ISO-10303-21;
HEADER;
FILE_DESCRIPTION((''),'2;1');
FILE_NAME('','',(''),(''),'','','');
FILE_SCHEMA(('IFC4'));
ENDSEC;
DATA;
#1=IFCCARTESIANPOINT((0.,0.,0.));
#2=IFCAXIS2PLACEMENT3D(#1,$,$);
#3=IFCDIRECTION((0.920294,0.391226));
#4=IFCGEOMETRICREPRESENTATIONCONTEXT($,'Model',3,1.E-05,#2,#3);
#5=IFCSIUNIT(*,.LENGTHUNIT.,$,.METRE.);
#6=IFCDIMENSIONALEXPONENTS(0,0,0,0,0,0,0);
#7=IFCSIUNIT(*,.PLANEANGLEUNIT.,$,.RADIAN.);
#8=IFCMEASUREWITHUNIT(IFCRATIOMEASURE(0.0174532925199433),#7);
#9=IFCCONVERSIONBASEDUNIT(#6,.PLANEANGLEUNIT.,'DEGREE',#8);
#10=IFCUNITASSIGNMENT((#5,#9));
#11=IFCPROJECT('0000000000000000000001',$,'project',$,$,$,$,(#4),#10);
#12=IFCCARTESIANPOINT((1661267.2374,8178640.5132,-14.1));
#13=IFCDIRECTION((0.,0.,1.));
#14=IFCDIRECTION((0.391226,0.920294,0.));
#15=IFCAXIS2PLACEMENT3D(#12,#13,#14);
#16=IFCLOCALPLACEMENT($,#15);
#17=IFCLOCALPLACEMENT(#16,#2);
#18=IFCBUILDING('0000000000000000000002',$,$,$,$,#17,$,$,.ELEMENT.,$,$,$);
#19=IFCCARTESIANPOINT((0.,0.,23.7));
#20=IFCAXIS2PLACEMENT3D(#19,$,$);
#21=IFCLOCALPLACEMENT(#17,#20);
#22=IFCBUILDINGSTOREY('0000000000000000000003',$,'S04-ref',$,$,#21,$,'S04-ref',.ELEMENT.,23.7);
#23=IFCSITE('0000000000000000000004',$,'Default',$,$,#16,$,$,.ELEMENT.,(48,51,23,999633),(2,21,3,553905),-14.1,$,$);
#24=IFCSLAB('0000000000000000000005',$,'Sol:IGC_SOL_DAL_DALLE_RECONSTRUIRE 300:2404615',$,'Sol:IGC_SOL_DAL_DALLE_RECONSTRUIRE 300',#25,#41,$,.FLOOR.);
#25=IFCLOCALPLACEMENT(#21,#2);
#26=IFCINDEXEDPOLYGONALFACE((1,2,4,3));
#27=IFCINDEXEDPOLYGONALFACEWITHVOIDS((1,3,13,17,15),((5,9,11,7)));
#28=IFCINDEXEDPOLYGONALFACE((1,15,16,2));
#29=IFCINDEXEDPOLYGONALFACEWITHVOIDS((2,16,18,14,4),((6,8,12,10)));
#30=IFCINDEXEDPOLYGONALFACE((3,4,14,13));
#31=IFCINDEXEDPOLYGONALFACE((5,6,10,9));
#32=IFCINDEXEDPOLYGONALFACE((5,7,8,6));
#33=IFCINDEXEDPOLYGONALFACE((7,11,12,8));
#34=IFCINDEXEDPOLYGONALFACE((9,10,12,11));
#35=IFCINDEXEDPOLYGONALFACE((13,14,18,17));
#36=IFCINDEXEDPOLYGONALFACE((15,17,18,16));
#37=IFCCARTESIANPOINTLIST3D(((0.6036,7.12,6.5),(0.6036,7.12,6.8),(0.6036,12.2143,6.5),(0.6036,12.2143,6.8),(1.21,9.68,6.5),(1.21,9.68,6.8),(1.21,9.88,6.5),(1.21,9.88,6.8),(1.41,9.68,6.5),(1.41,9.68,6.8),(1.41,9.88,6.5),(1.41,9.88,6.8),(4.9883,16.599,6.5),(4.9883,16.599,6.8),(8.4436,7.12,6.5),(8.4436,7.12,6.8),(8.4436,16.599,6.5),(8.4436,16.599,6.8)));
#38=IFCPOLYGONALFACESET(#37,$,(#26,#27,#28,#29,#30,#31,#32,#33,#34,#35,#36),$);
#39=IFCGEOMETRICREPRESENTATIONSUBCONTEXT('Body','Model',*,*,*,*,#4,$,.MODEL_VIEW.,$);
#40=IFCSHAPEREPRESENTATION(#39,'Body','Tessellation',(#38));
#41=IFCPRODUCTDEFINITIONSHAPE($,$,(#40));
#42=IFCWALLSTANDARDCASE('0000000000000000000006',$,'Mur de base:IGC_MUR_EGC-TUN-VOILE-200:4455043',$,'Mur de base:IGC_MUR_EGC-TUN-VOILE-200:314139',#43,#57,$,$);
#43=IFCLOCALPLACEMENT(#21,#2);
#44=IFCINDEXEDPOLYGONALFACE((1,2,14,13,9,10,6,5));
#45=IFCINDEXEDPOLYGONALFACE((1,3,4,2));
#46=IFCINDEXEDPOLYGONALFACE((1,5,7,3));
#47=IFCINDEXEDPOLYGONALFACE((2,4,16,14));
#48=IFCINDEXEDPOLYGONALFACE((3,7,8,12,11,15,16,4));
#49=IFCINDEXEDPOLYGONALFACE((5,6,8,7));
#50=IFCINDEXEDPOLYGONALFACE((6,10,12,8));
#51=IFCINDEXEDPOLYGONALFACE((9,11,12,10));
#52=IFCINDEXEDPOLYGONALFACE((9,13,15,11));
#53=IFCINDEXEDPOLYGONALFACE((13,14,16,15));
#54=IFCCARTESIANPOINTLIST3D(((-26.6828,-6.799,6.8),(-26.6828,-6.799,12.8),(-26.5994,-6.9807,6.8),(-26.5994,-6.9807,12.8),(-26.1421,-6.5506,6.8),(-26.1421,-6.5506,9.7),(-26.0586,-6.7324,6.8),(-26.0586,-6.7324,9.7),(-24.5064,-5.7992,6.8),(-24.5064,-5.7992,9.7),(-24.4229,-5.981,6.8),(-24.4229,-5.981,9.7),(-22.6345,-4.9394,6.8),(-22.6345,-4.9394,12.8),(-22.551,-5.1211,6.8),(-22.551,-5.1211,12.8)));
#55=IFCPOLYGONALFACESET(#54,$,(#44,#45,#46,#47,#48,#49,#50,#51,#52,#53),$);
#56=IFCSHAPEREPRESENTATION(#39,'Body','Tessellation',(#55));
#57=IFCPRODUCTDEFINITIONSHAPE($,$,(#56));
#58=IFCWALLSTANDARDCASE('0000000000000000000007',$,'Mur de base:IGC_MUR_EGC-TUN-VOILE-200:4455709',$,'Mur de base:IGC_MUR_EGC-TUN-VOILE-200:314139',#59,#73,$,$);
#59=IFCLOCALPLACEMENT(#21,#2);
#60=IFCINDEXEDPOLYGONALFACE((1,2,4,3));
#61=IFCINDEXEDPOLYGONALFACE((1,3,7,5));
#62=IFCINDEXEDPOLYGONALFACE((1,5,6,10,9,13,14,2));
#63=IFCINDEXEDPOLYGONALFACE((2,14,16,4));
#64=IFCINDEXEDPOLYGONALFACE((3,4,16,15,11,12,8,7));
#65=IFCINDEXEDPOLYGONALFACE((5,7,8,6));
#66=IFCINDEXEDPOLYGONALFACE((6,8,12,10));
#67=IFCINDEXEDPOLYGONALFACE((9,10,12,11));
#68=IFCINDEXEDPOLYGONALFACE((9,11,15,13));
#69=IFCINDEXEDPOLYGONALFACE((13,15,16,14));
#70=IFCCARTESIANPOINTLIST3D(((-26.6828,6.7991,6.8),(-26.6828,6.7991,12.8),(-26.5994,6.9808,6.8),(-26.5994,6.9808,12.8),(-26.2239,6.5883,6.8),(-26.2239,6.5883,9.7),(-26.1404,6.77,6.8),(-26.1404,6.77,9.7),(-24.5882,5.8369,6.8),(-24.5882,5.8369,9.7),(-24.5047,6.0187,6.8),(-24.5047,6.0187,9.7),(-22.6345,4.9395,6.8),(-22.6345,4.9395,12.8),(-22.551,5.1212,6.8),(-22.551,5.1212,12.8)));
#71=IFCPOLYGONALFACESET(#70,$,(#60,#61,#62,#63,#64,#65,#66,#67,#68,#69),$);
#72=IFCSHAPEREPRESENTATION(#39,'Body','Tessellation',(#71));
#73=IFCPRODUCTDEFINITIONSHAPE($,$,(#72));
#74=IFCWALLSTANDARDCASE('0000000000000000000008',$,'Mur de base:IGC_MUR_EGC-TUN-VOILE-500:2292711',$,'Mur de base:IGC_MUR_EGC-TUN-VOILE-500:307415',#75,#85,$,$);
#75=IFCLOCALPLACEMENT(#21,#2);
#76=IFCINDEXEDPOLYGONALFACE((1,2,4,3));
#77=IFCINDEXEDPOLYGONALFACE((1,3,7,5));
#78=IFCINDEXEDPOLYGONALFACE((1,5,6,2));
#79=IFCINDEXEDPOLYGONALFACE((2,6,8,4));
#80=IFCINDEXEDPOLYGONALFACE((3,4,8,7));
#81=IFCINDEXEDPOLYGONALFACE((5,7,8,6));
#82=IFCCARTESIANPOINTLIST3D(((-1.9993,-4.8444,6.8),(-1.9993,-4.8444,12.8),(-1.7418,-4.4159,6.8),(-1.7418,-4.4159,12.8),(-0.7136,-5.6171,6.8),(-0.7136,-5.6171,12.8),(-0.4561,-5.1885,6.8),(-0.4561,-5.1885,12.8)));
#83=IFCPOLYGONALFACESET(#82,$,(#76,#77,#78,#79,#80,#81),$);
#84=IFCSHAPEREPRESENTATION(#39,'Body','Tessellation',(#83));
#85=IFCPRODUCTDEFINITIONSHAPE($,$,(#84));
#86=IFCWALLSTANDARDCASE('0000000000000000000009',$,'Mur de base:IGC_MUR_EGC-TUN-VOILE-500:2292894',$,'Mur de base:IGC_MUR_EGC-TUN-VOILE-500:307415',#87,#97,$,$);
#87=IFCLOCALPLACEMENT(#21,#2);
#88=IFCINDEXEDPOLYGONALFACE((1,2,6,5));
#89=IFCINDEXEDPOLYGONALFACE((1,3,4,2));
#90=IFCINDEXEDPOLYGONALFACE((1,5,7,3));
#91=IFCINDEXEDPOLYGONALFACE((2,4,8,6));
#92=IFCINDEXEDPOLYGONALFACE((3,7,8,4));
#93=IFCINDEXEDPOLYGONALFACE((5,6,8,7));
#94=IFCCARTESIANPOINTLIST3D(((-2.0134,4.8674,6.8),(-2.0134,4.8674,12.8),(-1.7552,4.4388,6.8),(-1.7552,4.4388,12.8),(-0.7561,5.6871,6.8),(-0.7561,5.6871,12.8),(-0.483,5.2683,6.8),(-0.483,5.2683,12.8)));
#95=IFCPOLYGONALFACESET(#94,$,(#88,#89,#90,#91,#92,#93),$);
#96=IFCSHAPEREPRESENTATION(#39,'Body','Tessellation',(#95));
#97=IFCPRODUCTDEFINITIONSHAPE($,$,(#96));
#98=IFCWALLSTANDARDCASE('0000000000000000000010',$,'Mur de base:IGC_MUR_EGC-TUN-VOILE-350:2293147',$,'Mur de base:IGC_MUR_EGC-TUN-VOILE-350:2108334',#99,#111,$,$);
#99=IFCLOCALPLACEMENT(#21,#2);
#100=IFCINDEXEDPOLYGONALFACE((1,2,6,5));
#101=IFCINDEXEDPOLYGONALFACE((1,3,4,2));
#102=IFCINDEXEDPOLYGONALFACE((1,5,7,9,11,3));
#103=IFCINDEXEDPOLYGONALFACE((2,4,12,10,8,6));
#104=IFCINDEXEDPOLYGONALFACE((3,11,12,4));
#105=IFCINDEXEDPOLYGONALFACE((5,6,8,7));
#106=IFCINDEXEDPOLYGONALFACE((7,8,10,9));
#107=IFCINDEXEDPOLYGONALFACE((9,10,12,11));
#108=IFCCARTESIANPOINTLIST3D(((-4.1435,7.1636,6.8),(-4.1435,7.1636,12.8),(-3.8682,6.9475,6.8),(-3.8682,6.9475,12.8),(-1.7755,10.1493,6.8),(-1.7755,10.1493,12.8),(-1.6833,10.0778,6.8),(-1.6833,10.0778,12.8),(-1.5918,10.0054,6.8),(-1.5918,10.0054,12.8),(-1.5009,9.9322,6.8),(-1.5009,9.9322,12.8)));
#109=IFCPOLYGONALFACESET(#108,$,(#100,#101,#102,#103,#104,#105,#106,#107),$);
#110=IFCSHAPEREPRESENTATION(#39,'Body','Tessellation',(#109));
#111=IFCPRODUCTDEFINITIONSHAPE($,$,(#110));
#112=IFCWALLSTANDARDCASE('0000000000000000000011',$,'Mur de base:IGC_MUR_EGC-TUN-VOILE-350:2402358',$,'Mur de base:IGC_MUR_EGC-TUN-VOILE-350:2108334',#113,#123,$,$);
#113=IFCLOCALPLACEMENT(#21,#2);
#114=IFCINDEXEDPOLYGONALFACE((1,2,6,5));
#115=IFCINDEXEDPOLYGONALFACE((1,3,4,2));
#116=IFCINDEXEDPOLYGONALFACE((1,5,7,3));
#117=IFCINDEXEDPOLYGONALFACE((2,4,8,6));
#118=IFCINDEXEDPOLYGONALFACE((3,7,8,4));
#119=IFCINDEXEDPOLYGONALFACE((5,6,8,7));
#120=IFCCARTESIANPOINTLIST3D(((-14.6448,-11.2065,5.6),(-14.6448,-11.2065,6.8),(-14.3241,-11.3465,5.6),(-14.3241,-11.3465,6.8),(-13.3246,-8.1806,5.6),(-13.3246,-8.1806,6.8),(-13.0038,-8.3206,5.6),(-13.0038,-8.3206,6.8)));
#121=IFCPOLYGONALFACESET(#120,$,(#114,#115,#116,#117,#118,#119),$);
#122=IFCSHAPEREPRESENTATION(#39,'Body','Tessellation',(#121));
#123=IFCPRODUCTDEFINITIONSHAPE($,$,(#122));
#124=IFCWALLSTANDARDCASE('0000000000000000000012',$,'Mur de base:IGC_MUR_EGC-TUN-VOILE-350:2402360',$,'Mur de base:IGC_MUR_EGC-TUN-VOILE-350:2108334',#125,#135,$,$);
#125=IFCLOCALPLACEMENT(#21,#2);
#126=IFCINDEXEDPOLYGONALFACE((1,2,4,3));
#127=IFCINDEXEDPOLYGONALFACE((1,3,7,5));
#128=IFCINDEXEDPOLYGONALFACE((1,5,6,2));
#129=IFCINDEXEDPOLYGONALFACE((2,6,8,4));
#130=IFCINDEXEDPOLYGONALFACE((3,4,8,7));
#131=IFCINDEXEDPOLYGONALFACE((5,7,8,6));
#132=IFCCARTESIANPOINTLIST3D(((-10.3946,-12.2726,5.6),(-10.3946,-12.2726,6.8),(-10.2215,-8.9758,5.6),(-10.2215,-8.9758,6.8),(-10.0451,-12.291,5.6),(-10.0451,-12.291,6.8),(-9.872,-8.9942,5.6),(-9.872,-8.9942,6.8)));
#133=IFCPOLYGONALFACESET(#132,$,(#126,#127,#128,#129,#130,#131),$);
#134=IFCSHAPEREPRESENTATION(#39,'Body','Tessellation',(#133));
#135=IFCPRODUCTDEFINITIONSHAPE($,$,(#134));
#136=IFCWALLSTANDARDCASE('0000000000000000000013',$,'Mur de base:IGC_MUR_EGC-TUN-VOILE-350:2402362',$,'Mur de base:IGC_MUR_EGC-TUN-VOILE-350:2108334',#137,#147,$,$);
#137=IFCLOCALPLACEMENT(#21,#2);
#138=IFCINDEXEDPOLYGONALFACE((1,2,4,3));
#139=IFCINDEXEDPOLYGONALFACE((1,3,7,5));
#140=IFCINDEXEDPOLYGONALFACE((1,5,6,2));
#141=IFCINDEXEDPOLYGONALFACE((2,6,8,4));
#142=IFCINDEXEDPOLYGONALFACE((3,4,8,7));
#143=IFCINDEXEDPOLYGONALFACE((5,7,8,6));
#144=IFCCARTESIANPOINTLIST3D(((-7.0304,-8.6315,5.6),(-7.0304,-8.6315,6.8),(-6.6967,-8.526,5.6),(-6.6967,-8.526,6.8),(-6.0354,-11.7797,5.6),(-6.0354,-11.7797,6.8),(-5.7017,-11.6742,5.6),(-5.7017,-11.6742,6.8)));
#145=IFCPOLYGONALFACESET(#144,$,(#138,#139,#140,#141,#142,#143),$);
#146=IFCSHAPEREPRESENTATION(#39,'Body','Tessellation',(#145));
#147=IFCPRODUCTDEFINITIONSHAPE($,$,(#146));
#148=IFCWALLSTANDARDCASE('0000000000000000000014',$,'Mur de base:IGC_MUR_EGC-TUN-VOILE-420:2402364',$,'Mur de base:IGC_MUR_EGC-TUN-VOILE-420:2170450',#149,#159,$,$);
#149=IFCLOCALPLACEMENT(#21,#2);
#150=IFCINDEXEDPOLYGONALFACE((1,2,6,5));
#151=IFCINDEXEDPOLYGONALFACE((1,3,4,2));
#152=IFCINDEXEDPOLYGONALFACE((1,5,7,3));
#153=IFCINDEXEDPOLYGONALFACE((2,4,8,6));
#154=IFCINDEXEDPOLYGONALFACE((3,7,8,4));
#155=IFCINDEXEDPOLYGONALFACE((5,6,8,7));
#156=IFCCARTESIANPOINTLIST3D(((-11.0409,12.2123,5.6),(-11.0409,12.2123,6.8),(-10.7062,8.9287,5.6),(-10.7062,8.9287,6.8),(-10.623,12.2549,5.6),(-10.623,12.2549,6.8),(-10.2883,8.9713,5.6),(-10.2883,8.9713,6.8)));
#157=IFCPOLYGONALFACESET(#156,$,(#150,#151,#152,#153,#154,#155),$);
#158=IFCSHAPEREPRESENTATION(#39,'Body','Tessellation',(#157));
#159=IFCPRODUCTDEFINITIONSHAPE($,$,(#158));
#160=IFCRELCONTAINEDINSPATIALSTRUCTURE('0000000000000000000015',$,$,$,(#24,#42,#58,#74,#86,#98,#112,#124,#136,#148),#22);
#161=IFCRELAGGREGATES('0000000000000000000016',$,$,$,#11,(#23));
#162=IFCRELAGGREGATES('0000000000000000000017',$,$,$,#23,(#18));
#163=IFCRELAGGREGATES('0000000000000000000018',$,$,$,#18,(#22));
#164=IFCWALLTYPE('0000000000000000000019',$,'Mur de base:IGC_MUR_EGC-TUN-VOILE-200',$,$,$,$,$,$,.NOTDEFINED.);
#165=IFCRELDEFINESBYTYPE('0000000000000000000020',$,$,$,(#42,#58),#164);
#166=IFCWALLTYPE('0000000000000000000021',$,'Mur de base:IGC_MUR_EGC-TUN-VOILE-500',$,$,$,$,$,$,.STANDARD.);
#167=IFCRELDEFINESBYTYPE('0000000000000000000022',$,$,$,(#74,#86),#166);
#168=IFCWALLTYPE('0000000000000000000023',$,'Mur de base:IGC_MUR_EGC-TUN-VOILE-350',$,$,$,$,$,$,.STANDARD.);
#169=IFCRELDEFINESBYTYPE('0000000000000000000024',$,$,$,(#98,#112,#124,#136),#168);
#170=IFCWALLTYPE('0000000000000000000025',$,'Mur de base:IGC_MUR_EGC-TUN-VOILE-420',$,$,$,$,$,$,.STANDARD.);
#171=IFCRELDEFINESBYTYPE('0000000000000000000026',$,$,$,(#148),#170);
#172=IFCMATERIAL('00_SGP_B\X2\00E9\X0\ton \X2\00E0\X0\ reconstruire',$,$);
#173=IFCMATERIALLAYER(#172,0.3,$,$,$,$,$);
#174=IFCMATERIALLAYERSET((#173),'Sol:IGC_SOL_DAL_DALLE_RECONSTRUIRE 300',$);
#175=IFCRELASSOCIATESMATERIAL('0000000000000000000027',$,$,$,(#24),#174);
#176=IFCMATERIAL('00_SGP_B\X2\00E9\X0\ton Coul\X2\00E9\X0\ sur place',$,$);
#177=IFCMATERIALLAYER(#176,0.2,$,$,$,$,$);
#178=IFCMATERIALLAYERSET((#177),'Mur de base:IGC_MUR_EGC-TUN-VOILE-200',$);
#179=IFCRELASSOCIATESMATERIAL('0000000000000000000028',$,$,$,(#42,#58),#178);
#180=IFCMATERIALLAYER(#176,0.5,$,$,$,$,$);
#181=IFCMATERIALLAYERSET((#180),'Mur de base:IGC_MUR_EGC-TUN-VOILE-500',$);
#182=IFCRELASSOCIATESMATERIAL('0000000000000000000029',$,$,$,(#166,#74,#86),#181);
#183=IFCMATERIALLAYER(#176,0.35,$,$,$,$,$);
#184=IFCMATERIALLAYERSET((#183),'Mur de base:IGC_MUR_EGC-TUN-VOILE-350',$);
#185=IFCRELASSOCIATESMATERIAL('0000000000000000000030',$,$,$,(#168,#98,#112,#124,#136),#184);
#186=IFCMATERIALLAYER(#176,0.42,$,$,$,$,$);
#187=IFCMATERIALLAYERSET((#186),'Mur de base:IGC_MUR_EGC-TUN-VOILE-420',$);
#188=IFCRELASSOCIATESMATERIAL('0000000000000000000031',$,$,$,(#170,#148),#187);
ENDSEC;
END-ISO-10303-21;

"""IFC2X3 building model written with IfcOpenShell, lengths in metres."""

from ifc_helpers import new_model, entity, si_unit, converted_unit, direction, frame, frame_2d, origin, origin_2d_with_axis, place, context, subcontext, project, spatial, polyline, circle_curve, parameter, trimmed, segment, composite_curve, rectangle, outline, extrude, clip, bounded_halfspace, material, layer, layer_set, layer_usage, type_object, element, save


model = new_model("IFC2X3")

# Units and contexts
model_context = context("Model", 3, precision=1e-05, world=origin(), true_north=direction((0.920294, 0.391226)))
body_context = subcontext(model_context, "Body", "Model", "MODEL_VIEW")
ifc_project = project(units=[si_unit("LENGTHUNIT", "METRE"), converted_unit("PLANEANGLEUNIT", "DEGREE", entity("IfcRatioMeasure", 0.0174532925199433), si_unit("PLANEANGLEUNIT", "RADIAN"), dimensions=[0, 0, 0, 0, 0, 0, 0])], contexts=[model_context])

# Site, building, storey
site_placement = place(None, frame((1661267.2374, 8178640.5132, -14.1), z_axis=(0.0, 0.0, 1.0), x_axis=(0.391226, 0.920294, 0.0)))
site = spatial("IfcSite", under=ifc_project, at=site_placement, Name="Default", CompositionType="ELEMENT", RefLatitude=(48, 51, 23, 999633), RefLongitude=(2, 21, 3, 553905), RefElevation=-14.1)
building_placement = place(site_placement, origin())
building = spatial("IfcBuilding", under=site, at=building_placement, CompositionType="ELEMENT")
storey_placement = place(building_placement, frame((0.0, 0.0, 23.7)))
storey = spatial("IfcBuildingStorey", under=building, at=storey_placement, Name="S04-ref", LongName="S04-ref", CompositionType="ELEMENT", Elevation=23.7)

# Slab, opening
ifc_material_1 = material(Name="00_SGP_Béton à reconstruire")
ifc_layer_1 = layer(ifc_material_1, 0.3)
ifc_layer_set_1 = layer_set([ifc_layer_1], Name="Sol:IGC_SOL_DAL_DALLE_RECONSTRUIRE 300")
ifc_layer_usage_1 = layer_usage(ifc_layer_set_1, "AXIS3", "POSITIVE", 0.0)
slab_placement = place(storey_placement, frame((0.6036, 7.12, 6.5)))
slab = element("IfcSlab", 1, at=slab_placement, inside=storey, material=ifc_layer_usage_1, Name="Sol:IGC_SOL_DAL_DALLE_RECONSTRUIRE 300:2404615", ObjectType="Sol:IGC_SOL_DAL_DALLE_RECONSTRUIRE 300", PredefinedType="FLOOR", context=body_context, shape_type="SweptSolid", body=[
    extrude(outline(polyline([(-0.4647, 4.7395), (-3.92, 4.7395), (-3.92, -4.7395), (3.92, -4.7395), (3.92, 0.3548), (-0.4647, 4.7395)])), frame((3.92, 4.7395, 0.3), z_axis=(0.0, 0.0, -1.0), x_axis=(-1.0, 0.0, 0.0)), (0.0, 0.0, 1.0), 0.3),
])
opening_1_placement = place(slab_placement, origin())
element("IfcOpeningElement", 2, at=opening_1_placement, cuts=slab, ObjectType="Opening", context=body_context, shape_type="SweptSolid", body=[
    extrude(rectangle(XDim=0.2, YDim=0.2, at=origin_2d_with_axis()), frame((0.7064, 2.66, 0.0), z_axis=(0.0, 0.0, 1.0), x_axis=(-1.0, 0.0, 0.0)), (0.0, 0.0, 1.0), 0.3),
])

# Shared definitions
ifc_material_2 = material(Name="00_SGP_Béton Coulé sur place")
ifc_layer_2 = layer(ifc_material_2, 0.2)
ifc_layer_set_2 = layer_set([ifc_layer_2], Name="Mur de base:IGC_MUR_EGC-TUN-VOILE-200")
wall_type_1 = type_object("IfcWallType", Name="Mur de base:IGC_MUR_EGC-TUN-VOILE-200", PredefinedType="NOTDEFINED")

# Walls, openings
ifc_layer_usage_2 = layer_usage(ifc_layer_set_2, "AXIS2", "NEGATIVE", 0.1)
wall_1_placement = place(storey_placement, frame((-22.5927, -5.0302, 6.8), z_axis=(0.0, 0.0, 1.0), x_axis=(-0.908712, -0.417423, 0.0)))
wall_1 = element("IfcWallStandardCase", 3, at=wall_1_placement, inside=storey, type_object=wall_type_1, material=ifc_layer_usage_2, Name="Mur de base:IGC_MUR_EGC-TUN-VOILE-200:4455043", ObjectType="Mur de base:IGC_MUR_EGC-TUN-VOILE-200:314139", context=body_context, shape_type="SweptSolid", body=[
    extrude(rectangle(XDim=4.455, YDim=0.2, at=frame_2d((2.2275, 0.0), x_axis=(-1.0, 0.0))), origin(), (0.0, 0.0, 1.0), 6.0),
])
opening_2_placement = place(wall_1_placement, origin())
element("IfcOpeningElement", 4, at=opening_2_placement, cuts=wall_1, ObjectType="Opening", context=body_context, shape_type="SweptSolid", body=[
    extrude(rectangle(XDim=2.9, YDim=1.8, at=frame_2d((0.0, 0.0), x_axis=(0.0, 1.0))), frame((2.96, -1.624, 1.45), z_axis=(0.0, 1.0, 0.0), x_axis=(1.0, 0.0, 0.0)), (0.0, 0.0, 1.0), 3.048),
])
ifc_layer_usage_3 = layer_usage(ifc_layer_set_2, "AXIS2", "POSITIVE", -0.1)
wall_2_placement = place(storey_placement, frame((-22.5927, 5.0303, 6.8), z_axis=(0.0, 0.0, 1.0), x_axis=(-0.908714, 0.417419, 0.0)))
wall_2 = element("IfcWallStandardCase", 5, at=wall_2_placement, inside=storey, type_object=wall_type_1, material=ifc_layer_usage_3, Name="Mur de base:IGC_MUR_EGC-TUN-VOILE-200:4455709", ObjectType="Mur de base:IGC_MUR_EGC-TUN-VOILE-200:314139", context=body_context, shape_type="SweptSolid", body=[
    extrude(rectangle(XDim=4.455, YDim=0.2, at=frame_2d((2.2275, 0.0), x_axis=(-1.0, 0.0))), origin(), (0.0, 0.0, 1.0), 6.0),
])
opening_3_placement = place(wall_2_placement, origin())
element("IfcOpeningElement", 6, at=opening_3_placement, cuts=wall_2, ObjectType="Opening", context=body_context, shape_type="SweptSolid", body=[
    extrude(rectangle(XDim=2.9, YDim=1.8, at=frame_2d((0.0, 0.0), x_axis=(1.0, 0.0))), frame((3.05, -1.424, 1.45), z_axis=(0.0, 1.0, 0.0), x_axis=(0.0, 0.0, -1.0)), (0.0, 0.0, 1.0), 3.048),
])

# Walls
ifc_layer_3 = layer(ifc_material_2, 0.5)
ifc_layer_set_3 = layer_set([ifc_layer_3], Name="Mur de base:IGC_MUR_EGC-TUN-VOILE-500")
ifc_layer_usage_4 = layer_usage(ifc_layer_set_3, "AXIS2", "NEGATIVE", 0.25)
wall_type_2 = type_object("IfcWallType", Name="Mur de base:IGC_MUR_EGC-TUN-VOILE-500", PredefinedType="STANDARD", material=ifc_layer_set_3)
wall_3_placement = place(storey_placement, frame((-0.5848, -5.4028, 6.8), z_axis=(0.0, 0.0, 1.0), x_axis=(-0.857124, 0.51511, 0.0)))
element("IfcWallStandardCase", 7, at=wall_3_placement, inside=storey, type_object=wall_type_2, material=ifc_layer_usage_4, Name="Mur de base:IGC_MUR_EGC-TUN-VOILE-500:2292711", ObjectType="Mur de base:IGC_MUR_EGC-TUN-VOILE-500:307415", context=body_context, shape_type="Clipping", body=[
    clip(extrude(rectangle(XDim=1.5, YDim=0.5, at=frame_2d((0.75, 0.0), x_axis=(-1.0, 0.0))), origin(), (0.0, 0.0, 1.0), 6.0), bounded_halfspace(frame((1.5, -0.25, 6.0), z_axis=(-1.0, -0.000004, 0.0), x_axis=(0.0, 0.0, -1.0)), True, frame((1.5, -0.25, 6.0), z_axis=(-1.0, -0.000004, 0.0), x_axis=(0.0, 0.0, -1.0)), polyline([(0.0, 0.0), (0.0, -0.5), (6.0, -0.5), (6.0, 0.0), (0.0, 0.0)]))),
])
ifc_layer_usage_5 = layer_usage(ifc_layer_set_3, "AXIS2", "NEGATIVE", 0.25)
wall_4_placement = place(storey_placement, frame((-0.6195, 5.4777, 6.8), z_axis=(0.0, 0.0, 1.0), x_axis=(-0.837669, -0.546179, 0.0)))
element("IfcWallStandardCase", 8, at=wall_4_placement, inside=storey, type_object=wall_type_2, material=ifc_layer_usage_5, Name="Mur de base:IGC_MUR_EGC-TUN-VOILE-500:2292894", ObjectType="Mur de base:IGC_MUR_EGC-TUN-VOILE-500:307415", context=body_context, shape_type="Clipping", body=[
    clip(extrude(rectangle(XDim=1.5187, YDim=0.5, at=frame_2d((0.7594, 0.0), x_axis=(-1.0, 0.0))), origin(), (0.0, 0.0, 1.0), 6.0), bounded_halfspace(frame((1.5009, -0.25, 6.0), z_axis=(-0.999367, 0.035563, 0.0), x_axis=(0.0, 0.0, -1.0)), True, frame((1.5009, -0.25, 6.0), z_axis=(-0.999367, 0.035563, 0.0), x_axis=(0.0, 0.0, -1.0)), polyline([(0.0, 0.0), (0.0, -0.5003), (6.0, -0.5003), (6.0, 0.0), (0.0, 0.0)]))),
])
ifc_layer_4 = layer(ifc_material_2, 0.35)
ifc_layer_set_4 = layer_set([ifc_layer_4], Name="Mur de base:IGC_MUR_EGC-TUN-VOILE-350")
wall_type_3 = type_object("IfcWallType", Name="Mur de base:IGC_MUR_EGC-TUN-VOILE-350", PredefinedType="STANDARD", material=ifc_layer_set_4)
ifc_layer_usage_6 = layer_usage(ifc_layer_set_4, "AXIS2", "NEGATIVE", 0.175)
wall_5_placement = place(storey_placement, frame((-1.638, 10.041, 6.8), z_axis=(0.0, 0.0, 1.0), x_axis=(-0.621407, -0.783488, 0.0)))
element("IfcWallStandardCase", 9, at=wall_5_placement, inside=storey, type_object=wall_type_3, material=ifc_layer_usage_6, Name="Mur de base:IGC_MUR_EGC-TUN-VOILE-350:2293147", ObjectType="Mur de base:IGC_MUR_EGC-TUN-VOILE-350:2108334", context=body_context, shape_type="Clipping", body=[
    clip(extrude(outline(composite_curve([segment(polyline([(0.0006, -0.175), (0.5006, -0.175)]), True, "CONTINUOUS"), segment(polyline([(0.5006, -0.175), (3.8113, -0.175)]), True, "CONTINUOUS"), segment(polyline([(3.8113, -0.175), (3.8095, 0.175)]), True, "CONTINUOUS"), segment(polyline([(3.8095, 0.175), (0.0, 0.175)]), True, "CONTINUOUS"), segment(trimmed(circle_curve(frame_2d((12.7991, 0.021), x_axis=(-0.621407, 0.783488)), 12.8), [parameter(50.891835)], [parameter(52.458568)], True, "PARAMETER"), True, "CONTINUOUS")], self_intersect=False)), origin(), (0.0, 0.0, 1.0), 6.0), bounded_halfspace(frame((3.8113, -0.175, 6.0), z_axis=(-0.999987, -0.005128, 0.0), x_axis=(0.0, 0.0, -1.0)), True, frame((3.8113, -0.175, 6.0), z_axis=(-0.999987, -0.005128, 0.0), x_axis=(0.0, 0.0, -1.0)), polyline([(0.0, 0.0), (0.0, -0.35), (6.0, -0.35), (6.0, 0.0), (0.0, 0.0)]))),
])
ifc_layer_usage_7 = layer_usage(ifc_layer_set_4, "AXIS2", "POSITIVE", -0.175)
wall_6_placement = place(storey_placement, frame((-13.1642, -8.2506, 5.6), z_axis=(0.0, 0.0, 1.0), x_axis=(-0.39991, -0.916554, 0.0)))
element("IfcWallStandardCase", 10, at=wall_6_placement, inside=storey, type_object=wall_type_3, material=ifc_layer_usage_7, Name="Mur de base:IGC_MUR_EGC-TUN-VOILE-350:2402358", ObjectType="Mur de base:IGC_MUR_EGC-TUN-VOILE-350:2108334", context=body_context, shape_type="SweptSolid", body=[
    extrude(rectangle(XDim=3.3014, YDim=0.35, at=frame_2d((1.6507, 0.0), x_axis=(-1.0, 0.0))), origin(), (0.0, 0.0, 1.0), 1.2),
])
ifc_layer_usage_8 = layer_usage(ifc_layer_set_4, "AXIS2", "POSITIVE", -0.175)
wall_7_placement = place(storey_placement, frame((-10.0468, -8.985, 5.6), z_axis=(0.0, 0.0, 1.0), x_axis=(-0.052435, -0.998624, 0.0)))
element("IfcWallStandardCase", 11, at=wall_7_placement, inside=storey, type_object=wall_type_3, material=ifc_layer_usage_8, Name="Mur de base:IGC_MUR_EGC-TUN-VOILE-350:2402360", ObjectType="Mur de base:IGC_MUR_EGC-TUN-VOILE-350:2108334", context=body_context, shape_type="SweptSolid", body=[
    extrude(rectangle(XDim=3.3014, YDim=0.35, at=frame_2d((1.6507, 0.0), x_axis=(-1.0, 0.0))), origin(), (0.0, 0.0, 1.0), 1.2),
])
ifc_layer_usage_9 = layer_usage(ifc_layer_set_4, "AXIS2", "POSITIVE", -0.175)
wall_8_placement = place(storey_placement, frame((-6.8636, -8.5787, 5.6), z_axis=(0.0, 0.0, 1.0), x_axis=(0.301365, -0.953509, 0.0)))
element("IfcWallStandardCase", 12, at=wall_8_placement, inside=storey, type_object=wall_type_3, material=ifc_layer_usage_9, Name="Mur de base:IGC_MUR_EGC-TUN-VOILE-350:2402362", ObjectType="Mur de base:IGC_MUR_EGC-TUN-VOILE-350:2108334", context=body_context, shape_type="SweptSolid", body=[
    extrude(rectangle(XDim=3.3017, YDim=0.35, at=frame_2d((1.6508, 0.0), x_axis=(-1.0, 0.0))), origin(), (0.0, 0.0, 1.0), 1.2),
])
ifc_layer_5 = layer(ifc_material_2, 0.42)
ifc_layer_set_5 = layer_set([ifc_layer_5], Name="Mur de base:IGC_MUR_EGC-TUN-VOILE-420")
ifc_layer_usage_10 = layer_usage(ifc_layer_set_5, "AXIS2", "POSITIVE", -0.21)
wall_type_4 = type_object("IfcWallType", Name="Mur de base:IGC_MUR_EGC-TUN-VOILE-420", PredefinedType="STANDARD", material=ifc_layer_set_5)
wall_9_placement = place(storey_placement, frame((-10.4973, 8.95, 5.6), z_axis=(0.0, 0.0, 1.0), x_axis=(-0.101398, 0.994846, 0.0)))
element("IfcWallStandardCase", 13, at=wall_9_placement, inside=storey, type_object=wall_type_4, material=ifc_layer_usage_10, Name="Mur de base:IGC_MUR_EGC-TUN-VOILE-420:2402364", ObjectType="Mur de base:IGC_MUR_EGC-TUN-VOILE-420:2170450", context=body_context, shape_type="SweptSolid", body=[
    extrude(rectangle(XDim=3.3006, YDim=0.42, at=frame_2d((1.6503, 0.0), x_axis=(-1.0, 0.0))), origin(), (0.0, 0.0, 1.0), 1.2),
])

save(model, "model.ifc")
